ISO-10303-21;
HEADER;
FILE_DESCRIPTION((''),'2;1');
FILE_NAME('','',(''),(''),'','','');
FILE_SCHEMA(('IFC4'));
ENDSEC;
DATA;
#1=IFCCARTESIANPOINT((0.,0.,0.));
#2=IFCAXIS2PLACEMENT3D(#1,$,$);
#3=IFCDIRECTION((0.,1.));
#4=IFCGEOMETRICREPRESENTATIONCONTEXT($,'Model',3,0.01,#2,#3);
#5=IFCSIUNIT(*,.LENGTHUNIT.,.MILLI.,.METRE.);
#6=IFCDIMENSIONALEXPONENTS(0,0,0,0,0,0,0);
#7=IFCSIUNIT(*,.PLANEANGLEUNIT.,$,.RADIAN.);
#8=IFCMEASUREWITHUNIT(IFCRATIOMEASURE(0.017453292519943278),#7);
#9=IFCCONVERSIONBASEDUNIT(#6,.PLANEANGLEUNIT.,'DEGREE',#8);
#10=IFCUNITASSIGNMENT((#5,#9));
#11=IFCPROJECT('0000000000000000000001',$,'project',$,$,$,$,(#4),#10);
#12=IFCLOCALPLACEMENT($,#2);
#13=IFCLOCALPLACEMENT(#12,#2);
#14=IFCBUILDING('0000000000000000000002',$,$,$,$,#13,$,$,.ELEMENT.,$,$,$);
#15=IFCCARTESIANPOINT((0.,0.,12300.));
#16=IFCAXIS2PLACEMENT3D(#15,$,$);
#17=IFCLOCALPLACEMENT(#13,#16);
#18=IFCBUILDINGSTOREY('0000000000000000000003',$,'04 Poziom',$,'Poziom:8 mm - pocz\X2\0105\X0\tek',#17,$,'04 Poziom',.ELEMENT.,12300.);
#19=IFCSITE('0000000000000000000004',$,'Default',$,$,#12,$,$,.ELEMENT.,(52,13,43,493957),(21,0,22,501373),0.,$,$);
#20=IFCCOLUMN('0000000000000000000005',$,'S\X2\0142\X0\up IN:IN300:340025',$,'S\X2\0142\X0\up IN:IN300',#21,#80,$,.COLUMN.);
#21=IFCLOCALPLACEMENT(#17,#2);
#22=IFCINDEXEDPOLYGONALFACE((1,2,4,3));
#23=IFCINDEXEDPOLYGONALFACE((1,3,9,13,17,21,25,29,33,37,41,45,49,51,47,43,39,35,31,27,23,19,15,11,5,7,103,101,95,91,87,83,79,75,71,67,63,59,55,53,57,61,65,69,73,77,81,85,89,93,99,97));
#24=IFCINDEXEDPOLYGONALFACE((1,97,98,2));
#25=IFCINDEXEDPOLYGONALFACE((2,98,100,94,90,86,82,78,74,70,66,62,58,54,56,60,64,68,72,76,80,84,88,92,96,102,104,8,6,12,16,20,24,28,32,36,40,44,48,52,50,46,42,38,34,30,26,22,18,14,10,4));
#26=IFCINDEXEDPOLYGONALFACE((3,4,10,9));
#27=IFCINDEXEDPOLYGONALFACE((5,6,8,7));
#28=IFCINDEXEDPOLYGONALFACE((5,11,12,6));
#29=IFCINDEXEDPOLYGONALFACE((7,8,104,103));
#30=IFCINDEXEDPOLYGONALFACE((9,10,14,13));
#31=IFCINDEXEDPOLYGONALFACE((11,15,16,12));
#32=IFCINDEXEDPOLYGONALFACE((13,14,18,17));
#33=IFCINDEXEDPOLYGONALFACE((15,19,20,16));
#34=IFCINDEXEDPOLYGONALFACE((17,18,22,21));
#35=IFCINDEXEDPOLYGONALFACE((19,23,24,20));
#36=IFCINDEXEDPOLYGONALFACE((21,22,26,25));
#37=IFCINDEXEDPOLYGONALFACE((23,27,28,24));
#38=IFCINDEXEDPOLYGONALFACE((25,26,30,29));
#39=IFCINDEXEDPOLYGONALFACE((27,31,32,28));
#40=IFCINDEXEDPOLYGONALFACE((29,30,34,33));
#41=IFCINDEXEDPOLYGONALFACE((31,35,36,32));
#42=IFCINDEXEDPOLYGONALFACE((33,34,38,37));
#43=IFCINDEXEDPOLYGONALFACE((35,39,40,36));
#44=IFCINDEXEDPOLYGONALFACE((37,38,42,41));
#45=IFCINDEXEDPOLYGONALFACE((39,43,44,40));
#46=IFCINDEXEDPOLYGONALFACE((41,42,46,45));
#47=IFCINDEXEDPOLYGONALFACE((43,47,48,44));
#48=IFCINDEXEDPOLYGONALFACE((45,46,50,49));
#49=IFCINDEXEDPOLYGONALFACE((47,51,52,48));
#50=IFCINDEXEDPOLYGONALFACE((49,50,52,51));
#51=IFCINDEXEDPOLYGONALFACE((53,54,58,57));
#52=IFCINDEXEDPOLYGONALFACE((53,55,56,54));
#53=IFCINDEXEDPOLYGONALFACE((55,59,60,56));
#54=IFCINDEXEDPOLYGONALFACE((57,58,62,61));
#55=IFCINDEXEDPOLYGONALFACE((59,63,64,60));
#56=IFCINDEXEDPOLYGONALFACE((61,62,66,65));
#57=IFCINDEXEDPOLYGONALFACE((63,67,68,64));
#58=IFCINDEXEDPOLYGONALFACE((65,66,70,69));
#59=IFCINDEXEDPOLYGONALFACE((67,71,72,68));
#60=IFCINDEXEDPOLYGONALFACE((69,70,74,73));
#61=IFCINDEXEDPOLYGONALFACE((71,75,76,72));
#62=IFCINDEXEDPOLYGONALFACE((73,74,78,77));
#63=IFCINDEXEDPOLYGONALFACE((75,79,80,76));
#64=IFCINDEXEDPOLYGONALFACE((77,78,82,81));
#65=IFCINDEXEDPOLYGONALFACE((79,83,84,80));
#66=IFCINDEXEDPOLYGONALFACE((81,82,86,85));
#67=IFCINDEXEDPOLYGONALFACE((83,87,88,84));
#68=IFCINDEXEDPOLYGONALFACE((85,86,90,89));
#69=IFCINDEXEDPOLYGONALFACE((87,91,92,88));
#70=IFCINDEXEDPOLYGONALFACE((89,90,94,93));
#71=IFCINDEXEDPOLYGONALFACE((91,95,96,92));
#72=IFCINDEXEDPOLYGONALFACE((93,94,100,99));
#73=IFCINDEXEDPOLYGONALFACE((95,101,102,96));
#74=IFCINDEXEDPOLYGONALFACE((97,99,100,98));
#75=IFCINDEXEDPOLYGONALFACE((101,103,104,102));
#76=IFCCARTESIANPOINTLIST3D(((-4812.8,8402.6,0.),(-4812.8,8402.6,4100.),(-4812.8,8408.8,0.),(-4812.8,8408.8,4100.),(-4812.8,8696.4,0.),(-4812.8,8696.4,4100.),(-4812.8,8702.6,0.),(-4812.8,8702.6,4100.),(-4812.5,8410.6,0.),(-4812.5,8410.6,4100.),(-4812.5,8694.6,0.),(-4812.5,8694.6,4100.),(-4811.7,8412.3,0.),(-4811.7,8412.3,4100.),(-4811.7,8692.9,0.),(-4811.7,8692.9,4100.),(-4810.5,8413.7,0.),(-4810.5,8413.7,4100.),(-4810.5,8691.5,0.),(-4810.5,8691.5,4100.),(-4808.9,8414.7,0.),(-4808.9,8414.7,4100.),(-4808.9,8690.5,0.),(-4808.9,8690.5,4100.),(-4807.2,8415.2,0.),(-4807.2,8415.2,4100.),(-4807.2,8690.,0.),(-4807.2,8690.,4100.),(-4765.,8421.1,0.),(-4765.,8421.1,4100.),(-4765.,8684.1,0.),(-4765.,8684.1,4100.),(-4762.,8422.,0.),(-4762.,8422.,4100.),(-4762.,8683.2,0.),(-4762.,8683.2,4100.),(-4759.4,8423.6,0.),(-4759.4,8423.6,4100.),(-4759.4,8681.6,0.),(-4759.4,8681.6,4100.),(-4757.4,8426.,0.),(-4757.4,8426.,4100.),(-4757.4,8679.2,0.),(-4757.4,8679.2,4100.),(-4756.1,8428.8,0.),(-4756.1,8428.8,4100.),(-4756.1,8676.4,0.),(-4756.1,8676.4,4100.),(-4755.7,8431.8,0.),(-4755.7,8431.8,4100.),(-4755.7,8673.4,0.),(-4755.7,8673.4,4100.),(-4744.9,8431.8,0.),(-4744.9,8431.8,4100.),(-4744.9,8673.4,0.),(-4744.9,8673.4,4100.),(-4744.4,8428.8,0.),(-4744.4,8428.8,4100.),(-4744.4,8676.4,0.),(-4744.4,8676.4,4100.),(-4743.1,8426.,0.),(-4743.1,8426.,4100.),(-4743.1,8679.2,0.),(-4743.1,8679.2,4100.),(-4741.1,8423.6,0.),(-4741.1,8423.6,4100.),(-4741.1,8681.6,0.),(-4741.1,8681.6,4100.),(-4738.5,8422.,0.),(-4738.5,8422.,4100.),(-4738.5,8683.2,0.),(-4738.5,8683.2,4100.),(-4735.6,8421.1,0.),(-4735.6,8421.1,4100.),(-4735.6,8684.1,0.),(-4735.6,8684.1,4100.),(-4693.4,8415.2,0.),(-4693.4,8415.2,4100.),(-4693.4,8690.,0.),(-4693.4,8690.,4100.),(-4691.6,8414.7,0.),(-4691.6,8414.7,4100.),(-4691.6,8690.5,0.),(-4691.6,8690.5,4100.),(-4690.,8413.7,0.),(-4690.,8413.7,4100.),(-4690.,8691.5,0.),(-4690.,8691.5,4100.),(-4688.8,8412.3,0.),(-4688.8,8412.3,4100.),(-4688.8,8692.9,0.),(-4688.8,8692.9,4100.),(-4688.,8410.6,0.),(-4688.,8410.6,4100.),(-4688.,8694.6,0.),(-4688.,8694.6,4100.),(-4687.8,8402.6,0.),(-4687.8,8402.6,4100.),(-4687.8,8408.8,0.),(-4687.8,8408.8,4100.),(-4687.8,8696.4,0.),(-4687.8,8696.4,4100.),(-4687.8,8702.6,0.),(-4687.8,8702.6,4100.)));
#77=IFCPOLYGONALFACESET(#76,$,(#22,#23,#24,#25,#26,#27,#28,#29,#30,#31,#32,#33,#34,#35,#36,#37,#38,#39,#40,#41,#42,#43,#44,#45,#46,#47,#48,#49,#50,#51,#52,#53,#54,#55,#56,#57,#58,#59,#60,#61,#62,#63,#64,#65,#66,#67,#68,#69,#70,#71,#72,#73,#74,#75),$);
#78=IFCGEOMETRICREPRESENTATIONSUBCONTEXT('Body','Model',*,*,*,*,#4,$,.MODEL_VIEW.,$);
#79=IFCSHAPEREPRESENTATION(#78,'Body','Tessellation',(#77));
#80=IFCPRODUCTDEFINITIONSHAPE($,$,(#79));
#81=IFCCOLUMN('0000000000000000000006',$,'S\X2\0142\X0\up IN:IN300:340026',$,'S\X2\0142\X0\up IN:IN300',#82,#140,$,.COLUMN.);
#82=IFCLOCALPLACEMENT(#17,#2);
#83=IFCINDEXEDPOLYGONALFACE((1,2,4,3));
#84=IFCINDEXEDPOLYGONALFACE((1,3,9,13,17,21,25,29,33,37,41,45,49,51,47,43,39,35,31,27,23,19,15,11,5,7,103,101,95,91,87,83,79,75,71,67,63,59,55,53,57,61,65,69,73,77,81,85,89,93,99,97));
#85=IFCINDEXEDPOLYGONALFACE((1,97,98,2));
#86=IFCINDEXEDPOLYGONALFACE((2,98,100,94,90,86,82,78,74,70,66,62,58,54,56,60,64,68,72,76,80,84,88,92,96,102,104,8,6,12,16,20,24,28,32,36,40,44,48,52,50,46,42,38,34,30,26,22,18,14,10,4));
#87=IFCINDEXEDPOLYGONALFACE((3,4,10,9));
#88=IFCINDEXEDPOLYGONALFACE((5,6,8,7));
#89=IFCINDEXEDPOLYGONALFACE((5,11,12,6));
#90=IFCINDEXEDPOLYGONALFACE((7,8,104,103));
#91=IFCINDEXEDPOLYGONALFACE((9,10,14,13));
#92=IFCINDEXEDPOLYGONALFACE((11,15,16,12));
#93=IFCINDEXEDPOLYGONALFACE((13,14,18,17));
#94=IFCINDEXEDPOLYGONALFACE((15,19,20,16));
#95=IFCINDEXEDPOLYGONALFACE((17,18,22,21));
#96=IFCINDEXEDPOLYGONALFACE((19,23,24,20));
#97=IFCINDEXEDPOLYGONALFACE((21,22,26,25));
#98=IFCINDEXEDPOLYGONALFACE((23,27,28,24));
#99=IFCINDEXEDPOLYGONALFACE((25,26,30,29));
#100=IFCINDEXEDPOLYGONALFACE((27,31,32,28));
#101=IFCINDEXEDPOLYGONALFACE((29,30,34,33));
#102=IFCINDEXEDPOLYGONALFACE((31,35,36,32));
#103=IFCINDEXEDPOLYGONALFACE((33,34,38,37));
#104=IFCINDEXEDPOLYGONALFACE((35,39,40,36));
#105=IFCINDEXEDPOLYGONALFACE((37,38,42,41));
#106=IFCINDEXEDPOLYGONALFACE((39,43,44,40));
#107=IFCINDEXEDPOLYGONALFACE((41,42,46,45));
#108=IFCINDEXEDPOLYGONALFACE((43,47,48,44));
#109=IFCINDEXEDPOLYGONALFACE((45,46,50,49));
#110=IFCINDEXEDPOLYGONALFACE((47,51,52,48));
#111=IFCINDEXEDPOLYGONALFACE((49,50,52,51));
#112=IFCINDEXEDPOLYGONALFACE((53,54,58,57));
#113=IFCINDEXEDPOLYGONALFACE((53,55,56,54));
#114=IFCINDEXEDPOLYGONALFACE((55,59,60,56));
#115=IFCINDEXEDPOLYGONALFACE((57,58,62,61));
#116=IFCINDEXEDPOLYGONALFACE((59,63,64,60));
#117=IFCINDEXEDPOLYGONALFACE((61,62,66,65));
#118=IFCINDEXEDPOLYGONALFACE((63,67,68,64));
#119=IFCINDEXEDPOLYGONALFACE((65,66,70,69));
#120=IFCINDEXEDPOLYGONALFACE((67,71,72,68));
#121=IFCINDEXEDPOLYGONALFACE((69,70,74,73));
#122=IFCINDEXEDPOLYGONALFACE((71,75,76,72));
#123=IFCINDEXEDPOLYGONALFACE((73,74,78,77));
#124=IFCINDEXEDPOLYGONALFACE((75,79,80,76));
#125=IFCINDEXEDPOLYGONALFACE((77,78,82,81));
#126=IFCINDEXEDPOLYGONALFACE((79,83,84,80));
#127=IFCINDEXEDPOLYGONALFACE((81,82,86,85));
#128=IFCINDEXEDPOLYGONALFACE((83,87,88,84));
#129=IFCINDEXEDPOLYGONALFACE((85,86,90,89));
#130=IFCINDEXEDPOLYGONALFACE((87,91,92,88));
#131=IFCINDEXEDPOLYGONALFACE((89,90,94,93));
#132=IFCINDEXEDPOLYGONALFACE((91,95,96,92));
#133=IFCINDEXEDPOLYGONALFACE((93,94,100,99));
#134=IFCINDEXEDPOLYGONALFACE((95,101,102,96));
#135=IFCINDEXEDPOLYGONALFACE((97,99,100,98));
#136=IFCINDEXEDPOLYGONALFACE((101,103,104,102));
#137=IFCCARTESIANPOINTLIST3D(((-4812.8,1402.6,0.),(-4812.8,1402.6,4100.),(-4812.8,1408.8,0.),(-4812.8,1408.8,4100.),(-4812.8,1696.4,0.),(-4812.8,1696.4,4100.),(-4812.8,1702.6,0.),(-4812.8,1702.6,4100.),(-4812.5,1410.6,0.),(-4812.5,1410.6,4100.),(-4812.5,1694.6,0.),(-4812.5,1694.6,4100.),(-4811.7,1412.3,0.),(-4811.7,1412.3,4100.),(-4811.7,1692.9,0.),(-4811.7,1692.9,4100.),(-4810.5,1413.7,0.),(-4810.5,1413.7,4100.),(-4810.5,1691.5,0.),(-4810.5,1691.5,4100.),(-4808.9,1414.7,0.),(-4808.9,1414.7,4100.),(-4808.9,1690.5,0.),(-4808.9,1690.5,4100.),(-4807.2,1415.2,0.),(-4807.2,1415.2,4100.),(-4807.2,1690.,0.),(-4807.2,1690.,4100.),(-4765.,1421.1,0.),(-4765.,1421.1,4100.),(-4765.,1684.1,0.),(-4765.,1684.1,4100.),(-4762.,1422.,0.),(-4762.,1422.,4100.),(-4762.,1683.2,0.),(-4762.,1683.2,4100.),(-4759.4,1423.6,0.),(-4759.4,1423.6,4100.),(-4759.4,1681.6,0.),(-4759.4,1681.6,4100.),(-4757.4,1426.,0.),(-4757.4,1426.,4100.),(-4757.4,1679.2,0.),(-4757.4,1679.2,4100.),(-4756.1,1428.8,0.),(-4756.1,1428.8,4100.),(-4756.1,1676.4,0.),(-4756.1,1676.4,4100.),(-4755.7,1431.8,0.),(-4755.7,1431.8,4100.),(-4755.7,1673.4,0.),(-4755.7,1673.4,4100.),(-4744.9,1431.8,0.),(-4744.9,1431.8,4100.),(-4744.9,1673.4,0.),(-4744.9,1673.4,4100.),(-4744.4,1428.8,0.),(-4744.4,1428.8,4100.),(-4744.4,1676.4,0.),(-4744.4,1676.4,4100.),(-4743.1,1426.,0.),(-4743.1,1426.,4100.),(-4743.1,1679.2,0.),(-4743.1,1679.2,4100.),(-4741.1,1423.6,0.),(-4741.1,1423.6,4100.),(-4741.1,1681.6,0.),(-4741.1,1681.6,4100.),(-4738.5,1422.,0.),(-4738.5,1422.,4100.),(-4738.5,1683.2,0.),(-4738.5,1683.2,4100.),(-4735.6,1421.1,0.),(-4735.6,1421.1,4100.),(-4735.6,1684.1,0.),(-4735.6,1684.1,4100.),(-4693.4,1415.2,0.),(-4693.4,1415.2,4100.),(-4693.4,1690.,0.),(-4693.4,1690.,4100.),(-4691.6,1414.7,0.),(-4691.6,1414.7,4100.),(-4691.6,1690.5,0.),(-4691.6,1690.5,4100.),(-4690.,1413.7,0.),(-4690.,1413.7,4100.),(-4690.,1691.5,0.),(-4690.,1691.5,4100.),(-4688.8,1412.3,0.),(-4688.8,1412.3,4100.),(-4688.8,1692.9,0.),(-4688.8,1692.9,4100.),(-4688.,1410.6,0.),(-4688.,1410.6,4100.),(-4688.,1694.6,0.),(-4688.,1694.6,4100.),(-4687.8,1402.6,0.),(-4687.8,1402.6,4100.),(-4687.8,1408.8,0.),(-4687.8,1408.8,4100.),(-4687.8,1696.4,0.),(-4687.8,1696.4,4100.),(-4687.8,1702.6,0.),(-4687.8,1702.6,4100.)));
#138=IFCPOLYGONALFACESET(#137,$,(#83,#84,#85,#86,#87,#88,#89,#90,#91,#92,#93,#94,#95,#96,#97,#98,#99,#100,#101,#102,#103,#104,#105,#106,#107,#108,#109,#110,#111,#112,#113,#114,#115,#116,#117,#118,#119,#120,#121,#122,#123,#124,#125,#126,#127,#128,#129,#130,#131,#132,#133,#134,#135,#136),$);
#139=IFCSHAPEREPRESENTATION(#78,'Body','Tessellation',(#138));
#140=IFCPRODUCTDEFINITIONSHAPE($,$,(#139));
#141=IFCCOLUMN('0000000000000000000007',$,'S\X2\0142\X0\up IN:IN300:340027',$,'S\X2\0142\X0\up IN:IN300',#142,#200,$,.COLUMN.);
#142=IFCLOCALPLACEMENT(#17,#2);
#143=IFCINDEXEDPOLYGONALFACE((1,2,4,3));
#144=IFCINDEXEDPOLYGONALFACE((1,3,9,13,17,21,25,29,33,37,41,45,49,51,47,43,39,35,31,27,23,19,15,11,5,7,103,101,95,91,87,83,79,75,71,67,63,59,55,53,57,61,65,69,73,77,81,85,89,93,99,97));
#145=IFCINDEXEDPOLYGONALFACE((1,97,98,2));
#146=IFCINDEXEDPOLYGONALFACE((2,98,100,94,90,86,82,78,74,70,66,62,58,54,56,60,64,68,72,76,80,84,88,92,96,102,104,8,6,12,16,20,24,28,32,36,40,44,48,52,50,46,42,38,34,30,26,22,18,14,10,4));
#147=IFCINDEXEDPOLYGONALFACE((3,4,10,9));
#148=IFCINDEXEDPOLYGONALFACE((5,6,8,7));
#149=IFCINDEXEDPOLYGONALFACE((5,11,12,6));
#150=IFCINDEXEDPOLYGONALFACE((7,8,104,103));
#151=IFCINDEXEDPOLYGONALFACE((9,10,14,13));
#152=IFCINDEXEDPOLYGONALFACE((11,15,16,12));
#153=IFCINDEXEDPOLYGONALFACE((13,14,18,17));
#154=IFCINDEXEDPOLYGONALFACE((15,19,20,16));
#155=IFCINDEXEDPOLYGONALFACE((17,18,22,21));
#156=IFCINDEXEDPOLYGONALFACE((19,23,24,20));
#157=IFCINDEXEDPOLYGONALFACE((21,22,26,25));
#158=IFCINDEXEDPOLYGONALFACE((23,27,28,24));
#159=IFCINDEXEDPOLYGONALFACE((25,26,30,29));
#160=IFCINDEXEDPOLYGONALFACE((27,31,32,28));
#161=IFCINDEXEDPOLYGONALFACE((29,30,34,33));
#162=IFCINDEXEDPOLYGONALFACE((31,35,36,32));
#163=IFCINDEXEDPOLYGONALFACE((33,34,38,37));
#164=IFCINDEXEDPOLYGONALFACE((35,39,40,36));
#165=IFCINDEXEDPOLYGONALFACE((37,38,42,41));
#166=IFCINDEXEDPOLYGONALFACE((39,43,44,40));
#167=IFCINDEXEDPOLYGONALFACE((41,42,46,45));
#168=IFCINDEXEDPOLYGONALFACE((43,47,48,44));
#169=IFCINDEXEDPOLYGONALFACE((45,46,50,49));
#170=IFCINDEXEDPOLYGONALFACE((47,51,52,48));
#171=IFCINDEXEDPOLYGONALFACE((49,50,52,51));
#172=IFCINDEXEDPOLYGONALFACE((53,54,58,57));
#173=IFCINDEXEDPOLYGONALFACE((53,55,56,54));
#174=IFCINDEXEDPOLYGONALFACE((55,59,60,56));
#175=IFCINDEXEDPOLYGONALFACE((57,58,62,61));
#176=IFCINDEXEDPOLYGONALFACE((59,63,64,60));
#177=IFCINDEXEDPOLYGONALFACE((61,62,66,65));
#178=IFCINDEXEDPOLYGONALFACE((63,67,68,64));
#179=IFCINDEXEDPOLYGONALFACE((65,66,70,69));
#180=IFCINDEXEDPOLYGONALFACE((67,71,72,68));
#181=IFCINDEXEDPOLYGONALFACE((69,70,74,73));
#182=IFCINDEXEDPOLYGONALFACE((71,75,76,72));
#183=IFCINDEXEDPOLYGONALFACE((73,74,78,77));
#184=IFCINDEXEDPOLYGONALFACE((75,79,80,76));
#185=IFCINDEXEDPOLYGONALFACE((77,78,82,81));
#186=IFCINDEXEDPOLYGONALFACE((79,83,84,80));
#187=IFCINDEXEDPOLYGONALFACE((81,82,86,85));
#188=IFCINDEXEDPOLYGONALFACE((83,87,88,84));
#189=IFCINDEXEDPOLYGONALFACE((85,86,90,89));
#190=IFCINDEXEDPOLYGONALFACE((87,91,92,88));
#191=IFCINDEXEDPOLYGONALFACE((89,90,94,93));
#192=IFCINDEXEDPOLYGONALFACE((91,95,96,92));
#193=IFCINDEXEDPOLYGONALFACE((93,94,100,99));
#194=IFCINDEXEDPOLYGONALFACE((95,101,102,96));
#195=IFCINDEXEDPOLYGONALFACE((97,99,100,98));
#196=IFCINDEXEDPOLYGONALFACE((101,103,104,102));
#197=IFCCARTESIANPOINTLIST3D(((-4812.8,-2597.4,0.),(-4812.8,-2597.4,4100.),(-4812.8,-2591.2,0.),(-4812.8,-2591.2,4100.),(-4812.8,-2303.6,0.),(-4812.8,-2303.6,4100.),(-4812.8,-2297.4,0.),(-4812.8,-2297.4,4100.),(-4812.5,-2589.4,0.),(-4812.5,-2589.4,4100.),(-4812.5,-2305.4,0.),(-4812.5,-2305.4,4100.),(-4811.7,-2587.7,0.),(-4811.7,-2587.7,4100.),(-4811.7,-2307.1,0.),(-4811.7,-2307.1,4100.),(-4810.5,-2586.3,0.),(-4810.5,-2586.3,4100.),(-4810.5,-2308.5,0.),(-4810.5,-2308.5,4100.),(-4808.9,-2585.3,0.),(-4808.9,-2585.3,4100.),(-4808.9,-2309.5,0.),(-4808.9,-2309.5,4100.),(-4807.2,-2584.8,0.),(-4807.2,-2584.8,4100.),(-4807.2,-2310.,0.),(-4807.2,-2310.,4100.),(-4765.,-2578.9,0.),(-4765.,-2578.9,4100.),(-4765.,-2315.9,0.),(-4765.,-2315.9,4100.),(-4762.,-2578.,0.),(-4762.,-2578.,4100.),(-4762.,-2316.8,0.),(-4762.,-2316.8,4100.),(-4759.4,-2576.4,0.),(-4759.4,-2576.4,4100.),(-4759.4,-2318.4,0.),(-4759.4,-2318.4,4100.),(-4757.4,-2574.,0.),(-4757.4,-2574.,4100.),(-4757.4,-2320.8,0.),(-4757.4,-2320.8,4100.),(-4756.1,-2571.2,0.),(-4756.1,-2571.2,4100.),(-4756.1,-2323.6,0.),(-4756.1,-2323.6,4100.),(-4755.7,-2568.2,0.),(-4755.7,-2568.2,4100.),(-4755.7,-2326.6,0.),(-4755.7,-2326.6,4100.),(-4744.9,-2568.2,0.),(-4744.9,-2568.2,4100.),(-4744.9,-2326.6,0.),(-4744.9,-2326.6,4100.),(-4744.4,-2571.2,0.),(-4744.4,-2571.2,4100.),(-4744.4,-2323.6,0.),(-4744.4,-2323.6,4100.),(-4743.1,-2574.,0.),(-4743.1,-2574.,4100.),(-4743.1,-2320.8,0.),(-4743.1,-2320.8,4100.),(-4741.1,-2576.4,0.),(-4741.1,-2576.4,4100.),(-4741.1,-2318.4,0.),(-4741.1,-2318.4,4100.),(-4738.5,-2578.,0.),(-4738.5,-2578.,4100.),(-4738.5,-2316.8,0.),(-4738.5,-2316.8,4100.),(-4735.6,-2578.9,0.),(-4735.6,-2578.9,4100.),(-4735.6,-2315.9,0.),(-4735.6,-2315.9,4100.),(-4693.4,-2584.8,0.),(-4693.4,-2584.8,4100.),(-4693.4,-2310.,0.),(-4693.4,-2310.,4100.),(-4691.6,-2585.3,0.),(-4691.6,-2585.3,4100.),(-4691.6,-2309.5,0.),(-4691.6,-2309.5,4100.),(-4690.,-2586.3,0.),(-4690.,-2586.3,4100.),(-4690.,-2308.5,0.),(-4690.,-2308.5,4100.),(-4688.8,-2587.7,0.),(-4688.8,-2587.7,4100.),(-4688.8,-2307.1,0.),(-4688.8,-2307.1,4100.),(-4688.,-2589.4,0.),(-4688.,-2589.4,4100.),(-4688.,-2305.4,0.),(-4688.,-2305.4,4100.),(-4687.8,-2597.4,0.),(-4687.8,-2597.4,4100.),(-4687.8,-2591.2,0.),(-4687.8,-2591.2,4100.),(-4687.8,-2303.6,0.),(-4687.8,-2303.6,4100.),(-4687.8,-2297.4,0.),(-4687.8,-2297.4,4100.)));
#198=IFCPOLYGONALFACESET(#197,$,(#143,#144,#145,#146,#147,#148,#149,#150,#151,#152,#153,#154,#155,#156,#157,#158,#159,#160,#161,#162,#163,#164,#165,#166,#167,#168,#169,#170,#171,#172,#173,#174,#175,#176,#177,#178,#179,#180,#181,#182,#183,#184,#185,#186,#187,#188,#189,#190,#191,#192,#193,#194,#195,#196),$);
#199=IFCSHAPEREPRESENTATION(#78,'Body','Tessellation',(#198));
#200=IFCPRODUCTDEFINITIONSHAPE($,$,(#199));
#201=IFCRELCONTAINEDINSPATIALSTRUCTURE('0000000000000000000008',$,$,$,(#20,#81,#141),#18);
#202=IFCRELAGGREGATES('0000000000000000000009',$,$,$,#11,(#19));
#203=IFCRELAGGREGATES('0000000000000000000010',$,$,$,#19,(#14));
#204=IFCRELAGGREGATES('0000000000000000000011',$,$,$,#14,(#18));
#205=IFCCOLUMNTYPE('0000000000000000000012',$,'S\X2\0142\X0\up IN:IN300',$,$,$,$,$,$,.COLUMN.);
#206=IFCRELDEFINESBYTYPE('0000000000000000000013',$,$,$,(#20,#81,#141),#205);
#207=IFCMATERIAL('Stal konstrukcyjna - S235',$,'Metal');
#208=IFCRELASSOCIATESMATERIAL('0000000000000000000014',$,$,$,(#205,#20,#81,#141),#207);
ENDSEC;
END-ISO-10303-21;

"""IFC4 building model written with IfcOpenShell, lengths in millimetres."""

from ifc_helpers import new_model, entity, si_unit, converted_unit, direction, frame, origin, place, context, subcontext, project, spatial, line, arc, indexed_curve, outline, extrude, source, transform, mapped, material, type_object, type_shapes, element, save


model = new_model("IFC4")

# Units and contexts
model_context = context("Model", 3, precision=0.01, world=origin(), true_north=direction((0.0, 1.0)))
body_context = subcontext(model_context, "Body", "Model", "MODEL_VIEW")
ifc_project = project(units=[si_unit("LENGTHUNIT", "METRE", prefix="MILLI"), converted_unit("PLANEANGLEUNIT", "DEGREE", entity("IfcRatioMeasure", 0.017453292519943278), si_unit("PLANEANGLEUNIT", "RADIAN"), dimensions=[0, 0, 0, 0, 0, 0, 0])], contexts=[model_context])

# Site, building, storey
site_placement = place(None, origin())
site = spatial("IfcSite", under=ifc_project, at=site_placement, Name="Default", CompositionType="ELEMENT", RefLatitude=(52, 13, 43, 493957), RefLongitude=(21, 0, 22, 501373), RefElevation=0.0)
building_placement = place(site_placement, origin())
building = spatial("IfcBuilding", under=site, at=building_placement, CompositionType="ELEMENT")
storey_placement = place(building_placement, frame((0.0, 0.0, 12300.0)))
storey = spatial("IfcBuildingStorey", under=building, at=storey_placement, Name="04 Poziom", ObjectType="Poziom:8 mm - początek", LongName="04 Poziom", CompositionType="ELEMENT", Elevation=12300.0)

# Columns
ifc_material_1 = material(Name="Stal konstrukcyjna - S235", Category="Metal")
column_type = type_object("IfcColumnType", Name="Słup IN:IN300", PredefinedType="COLUMN", material=ifc_material_1)
shared_shape_1 = source(origin(), body_context, "Body", "SweptSolid", [
    extrude(outline(indexed_curve([(143.8, -62.5), (150.0, -62.5), (150.0, 62.5), (143.8, 62.5), (139.6, 60.9), (137.4, 56.9), (131.5, 14.7), (127.9, 8.1), (120.8, 5.4), (-120.8, 5.4), (-127.9, 8.1), (-131.5, 14.7), (-137.4, 56.9), (-139.6, 60.9), (-143.8, 62.5), (-150.0, 62.5), (-150.0, -62.5), (-143.8, -62.5), (-139.6, -60.9), (-137.4, -56.9), (-131.5, -14.7), (-127.9, -8.1), (-120.8, -5.4), (120.8, -5.4), (127.9, -8.1), (131.5, -14.7), (137.4, -56.9), (139.6, -60.9)], segments=[line(1, 2, 3, 4), arc(4, 5, 6), line(6, 7), arc(7, 8, 9), line(9, 10), arc(10, 11, 12), line(12, 13), arc(13, 14, 15), line(15, 16, 17, 18), arc(18, 19, 20), line(20, 21), arc(21, 22, 23), line(23, 24), arc(24, 25, 26), line(26, 27), arc(27, 28, 1)], self_intersect=False)), frame((0.0, 0.0, 12300.0), z_axis=(0.0, 0.0, 1.0), x_axis=(0.0, -1.0, 0.0)), (0.0, 0.0, 1.0), 4100.0),
])
type_shapes(column_type, [shared_shape_1])
for number, where, name in (
    (1, (-4750.3, 8552.6, -12300.0), "Słup IN:IN300:340025"),
    (2, (-4750.3, 1552.6, -12300.0), "Słup IN:IN300:340026"),
    (3, (-4750.3, -2447.4, -12300.0), "Słup IN:IN300:340027"),
):
    element("IfcColumn", number, at=place(storey_placement, frame(where)), inside=storey, type_object=column_type, material=ifc_material_1, Name=name, ObjectType="Słup IN:IN300", PredefinedType="COLUMN", context=body_context, shape_type="MappedRepresentation", body=[
        mapped(shared_shape_1, transform((0.0, 0.0, 0.0), scale=1.0)),
    ])

save(model, "model.ifc")
